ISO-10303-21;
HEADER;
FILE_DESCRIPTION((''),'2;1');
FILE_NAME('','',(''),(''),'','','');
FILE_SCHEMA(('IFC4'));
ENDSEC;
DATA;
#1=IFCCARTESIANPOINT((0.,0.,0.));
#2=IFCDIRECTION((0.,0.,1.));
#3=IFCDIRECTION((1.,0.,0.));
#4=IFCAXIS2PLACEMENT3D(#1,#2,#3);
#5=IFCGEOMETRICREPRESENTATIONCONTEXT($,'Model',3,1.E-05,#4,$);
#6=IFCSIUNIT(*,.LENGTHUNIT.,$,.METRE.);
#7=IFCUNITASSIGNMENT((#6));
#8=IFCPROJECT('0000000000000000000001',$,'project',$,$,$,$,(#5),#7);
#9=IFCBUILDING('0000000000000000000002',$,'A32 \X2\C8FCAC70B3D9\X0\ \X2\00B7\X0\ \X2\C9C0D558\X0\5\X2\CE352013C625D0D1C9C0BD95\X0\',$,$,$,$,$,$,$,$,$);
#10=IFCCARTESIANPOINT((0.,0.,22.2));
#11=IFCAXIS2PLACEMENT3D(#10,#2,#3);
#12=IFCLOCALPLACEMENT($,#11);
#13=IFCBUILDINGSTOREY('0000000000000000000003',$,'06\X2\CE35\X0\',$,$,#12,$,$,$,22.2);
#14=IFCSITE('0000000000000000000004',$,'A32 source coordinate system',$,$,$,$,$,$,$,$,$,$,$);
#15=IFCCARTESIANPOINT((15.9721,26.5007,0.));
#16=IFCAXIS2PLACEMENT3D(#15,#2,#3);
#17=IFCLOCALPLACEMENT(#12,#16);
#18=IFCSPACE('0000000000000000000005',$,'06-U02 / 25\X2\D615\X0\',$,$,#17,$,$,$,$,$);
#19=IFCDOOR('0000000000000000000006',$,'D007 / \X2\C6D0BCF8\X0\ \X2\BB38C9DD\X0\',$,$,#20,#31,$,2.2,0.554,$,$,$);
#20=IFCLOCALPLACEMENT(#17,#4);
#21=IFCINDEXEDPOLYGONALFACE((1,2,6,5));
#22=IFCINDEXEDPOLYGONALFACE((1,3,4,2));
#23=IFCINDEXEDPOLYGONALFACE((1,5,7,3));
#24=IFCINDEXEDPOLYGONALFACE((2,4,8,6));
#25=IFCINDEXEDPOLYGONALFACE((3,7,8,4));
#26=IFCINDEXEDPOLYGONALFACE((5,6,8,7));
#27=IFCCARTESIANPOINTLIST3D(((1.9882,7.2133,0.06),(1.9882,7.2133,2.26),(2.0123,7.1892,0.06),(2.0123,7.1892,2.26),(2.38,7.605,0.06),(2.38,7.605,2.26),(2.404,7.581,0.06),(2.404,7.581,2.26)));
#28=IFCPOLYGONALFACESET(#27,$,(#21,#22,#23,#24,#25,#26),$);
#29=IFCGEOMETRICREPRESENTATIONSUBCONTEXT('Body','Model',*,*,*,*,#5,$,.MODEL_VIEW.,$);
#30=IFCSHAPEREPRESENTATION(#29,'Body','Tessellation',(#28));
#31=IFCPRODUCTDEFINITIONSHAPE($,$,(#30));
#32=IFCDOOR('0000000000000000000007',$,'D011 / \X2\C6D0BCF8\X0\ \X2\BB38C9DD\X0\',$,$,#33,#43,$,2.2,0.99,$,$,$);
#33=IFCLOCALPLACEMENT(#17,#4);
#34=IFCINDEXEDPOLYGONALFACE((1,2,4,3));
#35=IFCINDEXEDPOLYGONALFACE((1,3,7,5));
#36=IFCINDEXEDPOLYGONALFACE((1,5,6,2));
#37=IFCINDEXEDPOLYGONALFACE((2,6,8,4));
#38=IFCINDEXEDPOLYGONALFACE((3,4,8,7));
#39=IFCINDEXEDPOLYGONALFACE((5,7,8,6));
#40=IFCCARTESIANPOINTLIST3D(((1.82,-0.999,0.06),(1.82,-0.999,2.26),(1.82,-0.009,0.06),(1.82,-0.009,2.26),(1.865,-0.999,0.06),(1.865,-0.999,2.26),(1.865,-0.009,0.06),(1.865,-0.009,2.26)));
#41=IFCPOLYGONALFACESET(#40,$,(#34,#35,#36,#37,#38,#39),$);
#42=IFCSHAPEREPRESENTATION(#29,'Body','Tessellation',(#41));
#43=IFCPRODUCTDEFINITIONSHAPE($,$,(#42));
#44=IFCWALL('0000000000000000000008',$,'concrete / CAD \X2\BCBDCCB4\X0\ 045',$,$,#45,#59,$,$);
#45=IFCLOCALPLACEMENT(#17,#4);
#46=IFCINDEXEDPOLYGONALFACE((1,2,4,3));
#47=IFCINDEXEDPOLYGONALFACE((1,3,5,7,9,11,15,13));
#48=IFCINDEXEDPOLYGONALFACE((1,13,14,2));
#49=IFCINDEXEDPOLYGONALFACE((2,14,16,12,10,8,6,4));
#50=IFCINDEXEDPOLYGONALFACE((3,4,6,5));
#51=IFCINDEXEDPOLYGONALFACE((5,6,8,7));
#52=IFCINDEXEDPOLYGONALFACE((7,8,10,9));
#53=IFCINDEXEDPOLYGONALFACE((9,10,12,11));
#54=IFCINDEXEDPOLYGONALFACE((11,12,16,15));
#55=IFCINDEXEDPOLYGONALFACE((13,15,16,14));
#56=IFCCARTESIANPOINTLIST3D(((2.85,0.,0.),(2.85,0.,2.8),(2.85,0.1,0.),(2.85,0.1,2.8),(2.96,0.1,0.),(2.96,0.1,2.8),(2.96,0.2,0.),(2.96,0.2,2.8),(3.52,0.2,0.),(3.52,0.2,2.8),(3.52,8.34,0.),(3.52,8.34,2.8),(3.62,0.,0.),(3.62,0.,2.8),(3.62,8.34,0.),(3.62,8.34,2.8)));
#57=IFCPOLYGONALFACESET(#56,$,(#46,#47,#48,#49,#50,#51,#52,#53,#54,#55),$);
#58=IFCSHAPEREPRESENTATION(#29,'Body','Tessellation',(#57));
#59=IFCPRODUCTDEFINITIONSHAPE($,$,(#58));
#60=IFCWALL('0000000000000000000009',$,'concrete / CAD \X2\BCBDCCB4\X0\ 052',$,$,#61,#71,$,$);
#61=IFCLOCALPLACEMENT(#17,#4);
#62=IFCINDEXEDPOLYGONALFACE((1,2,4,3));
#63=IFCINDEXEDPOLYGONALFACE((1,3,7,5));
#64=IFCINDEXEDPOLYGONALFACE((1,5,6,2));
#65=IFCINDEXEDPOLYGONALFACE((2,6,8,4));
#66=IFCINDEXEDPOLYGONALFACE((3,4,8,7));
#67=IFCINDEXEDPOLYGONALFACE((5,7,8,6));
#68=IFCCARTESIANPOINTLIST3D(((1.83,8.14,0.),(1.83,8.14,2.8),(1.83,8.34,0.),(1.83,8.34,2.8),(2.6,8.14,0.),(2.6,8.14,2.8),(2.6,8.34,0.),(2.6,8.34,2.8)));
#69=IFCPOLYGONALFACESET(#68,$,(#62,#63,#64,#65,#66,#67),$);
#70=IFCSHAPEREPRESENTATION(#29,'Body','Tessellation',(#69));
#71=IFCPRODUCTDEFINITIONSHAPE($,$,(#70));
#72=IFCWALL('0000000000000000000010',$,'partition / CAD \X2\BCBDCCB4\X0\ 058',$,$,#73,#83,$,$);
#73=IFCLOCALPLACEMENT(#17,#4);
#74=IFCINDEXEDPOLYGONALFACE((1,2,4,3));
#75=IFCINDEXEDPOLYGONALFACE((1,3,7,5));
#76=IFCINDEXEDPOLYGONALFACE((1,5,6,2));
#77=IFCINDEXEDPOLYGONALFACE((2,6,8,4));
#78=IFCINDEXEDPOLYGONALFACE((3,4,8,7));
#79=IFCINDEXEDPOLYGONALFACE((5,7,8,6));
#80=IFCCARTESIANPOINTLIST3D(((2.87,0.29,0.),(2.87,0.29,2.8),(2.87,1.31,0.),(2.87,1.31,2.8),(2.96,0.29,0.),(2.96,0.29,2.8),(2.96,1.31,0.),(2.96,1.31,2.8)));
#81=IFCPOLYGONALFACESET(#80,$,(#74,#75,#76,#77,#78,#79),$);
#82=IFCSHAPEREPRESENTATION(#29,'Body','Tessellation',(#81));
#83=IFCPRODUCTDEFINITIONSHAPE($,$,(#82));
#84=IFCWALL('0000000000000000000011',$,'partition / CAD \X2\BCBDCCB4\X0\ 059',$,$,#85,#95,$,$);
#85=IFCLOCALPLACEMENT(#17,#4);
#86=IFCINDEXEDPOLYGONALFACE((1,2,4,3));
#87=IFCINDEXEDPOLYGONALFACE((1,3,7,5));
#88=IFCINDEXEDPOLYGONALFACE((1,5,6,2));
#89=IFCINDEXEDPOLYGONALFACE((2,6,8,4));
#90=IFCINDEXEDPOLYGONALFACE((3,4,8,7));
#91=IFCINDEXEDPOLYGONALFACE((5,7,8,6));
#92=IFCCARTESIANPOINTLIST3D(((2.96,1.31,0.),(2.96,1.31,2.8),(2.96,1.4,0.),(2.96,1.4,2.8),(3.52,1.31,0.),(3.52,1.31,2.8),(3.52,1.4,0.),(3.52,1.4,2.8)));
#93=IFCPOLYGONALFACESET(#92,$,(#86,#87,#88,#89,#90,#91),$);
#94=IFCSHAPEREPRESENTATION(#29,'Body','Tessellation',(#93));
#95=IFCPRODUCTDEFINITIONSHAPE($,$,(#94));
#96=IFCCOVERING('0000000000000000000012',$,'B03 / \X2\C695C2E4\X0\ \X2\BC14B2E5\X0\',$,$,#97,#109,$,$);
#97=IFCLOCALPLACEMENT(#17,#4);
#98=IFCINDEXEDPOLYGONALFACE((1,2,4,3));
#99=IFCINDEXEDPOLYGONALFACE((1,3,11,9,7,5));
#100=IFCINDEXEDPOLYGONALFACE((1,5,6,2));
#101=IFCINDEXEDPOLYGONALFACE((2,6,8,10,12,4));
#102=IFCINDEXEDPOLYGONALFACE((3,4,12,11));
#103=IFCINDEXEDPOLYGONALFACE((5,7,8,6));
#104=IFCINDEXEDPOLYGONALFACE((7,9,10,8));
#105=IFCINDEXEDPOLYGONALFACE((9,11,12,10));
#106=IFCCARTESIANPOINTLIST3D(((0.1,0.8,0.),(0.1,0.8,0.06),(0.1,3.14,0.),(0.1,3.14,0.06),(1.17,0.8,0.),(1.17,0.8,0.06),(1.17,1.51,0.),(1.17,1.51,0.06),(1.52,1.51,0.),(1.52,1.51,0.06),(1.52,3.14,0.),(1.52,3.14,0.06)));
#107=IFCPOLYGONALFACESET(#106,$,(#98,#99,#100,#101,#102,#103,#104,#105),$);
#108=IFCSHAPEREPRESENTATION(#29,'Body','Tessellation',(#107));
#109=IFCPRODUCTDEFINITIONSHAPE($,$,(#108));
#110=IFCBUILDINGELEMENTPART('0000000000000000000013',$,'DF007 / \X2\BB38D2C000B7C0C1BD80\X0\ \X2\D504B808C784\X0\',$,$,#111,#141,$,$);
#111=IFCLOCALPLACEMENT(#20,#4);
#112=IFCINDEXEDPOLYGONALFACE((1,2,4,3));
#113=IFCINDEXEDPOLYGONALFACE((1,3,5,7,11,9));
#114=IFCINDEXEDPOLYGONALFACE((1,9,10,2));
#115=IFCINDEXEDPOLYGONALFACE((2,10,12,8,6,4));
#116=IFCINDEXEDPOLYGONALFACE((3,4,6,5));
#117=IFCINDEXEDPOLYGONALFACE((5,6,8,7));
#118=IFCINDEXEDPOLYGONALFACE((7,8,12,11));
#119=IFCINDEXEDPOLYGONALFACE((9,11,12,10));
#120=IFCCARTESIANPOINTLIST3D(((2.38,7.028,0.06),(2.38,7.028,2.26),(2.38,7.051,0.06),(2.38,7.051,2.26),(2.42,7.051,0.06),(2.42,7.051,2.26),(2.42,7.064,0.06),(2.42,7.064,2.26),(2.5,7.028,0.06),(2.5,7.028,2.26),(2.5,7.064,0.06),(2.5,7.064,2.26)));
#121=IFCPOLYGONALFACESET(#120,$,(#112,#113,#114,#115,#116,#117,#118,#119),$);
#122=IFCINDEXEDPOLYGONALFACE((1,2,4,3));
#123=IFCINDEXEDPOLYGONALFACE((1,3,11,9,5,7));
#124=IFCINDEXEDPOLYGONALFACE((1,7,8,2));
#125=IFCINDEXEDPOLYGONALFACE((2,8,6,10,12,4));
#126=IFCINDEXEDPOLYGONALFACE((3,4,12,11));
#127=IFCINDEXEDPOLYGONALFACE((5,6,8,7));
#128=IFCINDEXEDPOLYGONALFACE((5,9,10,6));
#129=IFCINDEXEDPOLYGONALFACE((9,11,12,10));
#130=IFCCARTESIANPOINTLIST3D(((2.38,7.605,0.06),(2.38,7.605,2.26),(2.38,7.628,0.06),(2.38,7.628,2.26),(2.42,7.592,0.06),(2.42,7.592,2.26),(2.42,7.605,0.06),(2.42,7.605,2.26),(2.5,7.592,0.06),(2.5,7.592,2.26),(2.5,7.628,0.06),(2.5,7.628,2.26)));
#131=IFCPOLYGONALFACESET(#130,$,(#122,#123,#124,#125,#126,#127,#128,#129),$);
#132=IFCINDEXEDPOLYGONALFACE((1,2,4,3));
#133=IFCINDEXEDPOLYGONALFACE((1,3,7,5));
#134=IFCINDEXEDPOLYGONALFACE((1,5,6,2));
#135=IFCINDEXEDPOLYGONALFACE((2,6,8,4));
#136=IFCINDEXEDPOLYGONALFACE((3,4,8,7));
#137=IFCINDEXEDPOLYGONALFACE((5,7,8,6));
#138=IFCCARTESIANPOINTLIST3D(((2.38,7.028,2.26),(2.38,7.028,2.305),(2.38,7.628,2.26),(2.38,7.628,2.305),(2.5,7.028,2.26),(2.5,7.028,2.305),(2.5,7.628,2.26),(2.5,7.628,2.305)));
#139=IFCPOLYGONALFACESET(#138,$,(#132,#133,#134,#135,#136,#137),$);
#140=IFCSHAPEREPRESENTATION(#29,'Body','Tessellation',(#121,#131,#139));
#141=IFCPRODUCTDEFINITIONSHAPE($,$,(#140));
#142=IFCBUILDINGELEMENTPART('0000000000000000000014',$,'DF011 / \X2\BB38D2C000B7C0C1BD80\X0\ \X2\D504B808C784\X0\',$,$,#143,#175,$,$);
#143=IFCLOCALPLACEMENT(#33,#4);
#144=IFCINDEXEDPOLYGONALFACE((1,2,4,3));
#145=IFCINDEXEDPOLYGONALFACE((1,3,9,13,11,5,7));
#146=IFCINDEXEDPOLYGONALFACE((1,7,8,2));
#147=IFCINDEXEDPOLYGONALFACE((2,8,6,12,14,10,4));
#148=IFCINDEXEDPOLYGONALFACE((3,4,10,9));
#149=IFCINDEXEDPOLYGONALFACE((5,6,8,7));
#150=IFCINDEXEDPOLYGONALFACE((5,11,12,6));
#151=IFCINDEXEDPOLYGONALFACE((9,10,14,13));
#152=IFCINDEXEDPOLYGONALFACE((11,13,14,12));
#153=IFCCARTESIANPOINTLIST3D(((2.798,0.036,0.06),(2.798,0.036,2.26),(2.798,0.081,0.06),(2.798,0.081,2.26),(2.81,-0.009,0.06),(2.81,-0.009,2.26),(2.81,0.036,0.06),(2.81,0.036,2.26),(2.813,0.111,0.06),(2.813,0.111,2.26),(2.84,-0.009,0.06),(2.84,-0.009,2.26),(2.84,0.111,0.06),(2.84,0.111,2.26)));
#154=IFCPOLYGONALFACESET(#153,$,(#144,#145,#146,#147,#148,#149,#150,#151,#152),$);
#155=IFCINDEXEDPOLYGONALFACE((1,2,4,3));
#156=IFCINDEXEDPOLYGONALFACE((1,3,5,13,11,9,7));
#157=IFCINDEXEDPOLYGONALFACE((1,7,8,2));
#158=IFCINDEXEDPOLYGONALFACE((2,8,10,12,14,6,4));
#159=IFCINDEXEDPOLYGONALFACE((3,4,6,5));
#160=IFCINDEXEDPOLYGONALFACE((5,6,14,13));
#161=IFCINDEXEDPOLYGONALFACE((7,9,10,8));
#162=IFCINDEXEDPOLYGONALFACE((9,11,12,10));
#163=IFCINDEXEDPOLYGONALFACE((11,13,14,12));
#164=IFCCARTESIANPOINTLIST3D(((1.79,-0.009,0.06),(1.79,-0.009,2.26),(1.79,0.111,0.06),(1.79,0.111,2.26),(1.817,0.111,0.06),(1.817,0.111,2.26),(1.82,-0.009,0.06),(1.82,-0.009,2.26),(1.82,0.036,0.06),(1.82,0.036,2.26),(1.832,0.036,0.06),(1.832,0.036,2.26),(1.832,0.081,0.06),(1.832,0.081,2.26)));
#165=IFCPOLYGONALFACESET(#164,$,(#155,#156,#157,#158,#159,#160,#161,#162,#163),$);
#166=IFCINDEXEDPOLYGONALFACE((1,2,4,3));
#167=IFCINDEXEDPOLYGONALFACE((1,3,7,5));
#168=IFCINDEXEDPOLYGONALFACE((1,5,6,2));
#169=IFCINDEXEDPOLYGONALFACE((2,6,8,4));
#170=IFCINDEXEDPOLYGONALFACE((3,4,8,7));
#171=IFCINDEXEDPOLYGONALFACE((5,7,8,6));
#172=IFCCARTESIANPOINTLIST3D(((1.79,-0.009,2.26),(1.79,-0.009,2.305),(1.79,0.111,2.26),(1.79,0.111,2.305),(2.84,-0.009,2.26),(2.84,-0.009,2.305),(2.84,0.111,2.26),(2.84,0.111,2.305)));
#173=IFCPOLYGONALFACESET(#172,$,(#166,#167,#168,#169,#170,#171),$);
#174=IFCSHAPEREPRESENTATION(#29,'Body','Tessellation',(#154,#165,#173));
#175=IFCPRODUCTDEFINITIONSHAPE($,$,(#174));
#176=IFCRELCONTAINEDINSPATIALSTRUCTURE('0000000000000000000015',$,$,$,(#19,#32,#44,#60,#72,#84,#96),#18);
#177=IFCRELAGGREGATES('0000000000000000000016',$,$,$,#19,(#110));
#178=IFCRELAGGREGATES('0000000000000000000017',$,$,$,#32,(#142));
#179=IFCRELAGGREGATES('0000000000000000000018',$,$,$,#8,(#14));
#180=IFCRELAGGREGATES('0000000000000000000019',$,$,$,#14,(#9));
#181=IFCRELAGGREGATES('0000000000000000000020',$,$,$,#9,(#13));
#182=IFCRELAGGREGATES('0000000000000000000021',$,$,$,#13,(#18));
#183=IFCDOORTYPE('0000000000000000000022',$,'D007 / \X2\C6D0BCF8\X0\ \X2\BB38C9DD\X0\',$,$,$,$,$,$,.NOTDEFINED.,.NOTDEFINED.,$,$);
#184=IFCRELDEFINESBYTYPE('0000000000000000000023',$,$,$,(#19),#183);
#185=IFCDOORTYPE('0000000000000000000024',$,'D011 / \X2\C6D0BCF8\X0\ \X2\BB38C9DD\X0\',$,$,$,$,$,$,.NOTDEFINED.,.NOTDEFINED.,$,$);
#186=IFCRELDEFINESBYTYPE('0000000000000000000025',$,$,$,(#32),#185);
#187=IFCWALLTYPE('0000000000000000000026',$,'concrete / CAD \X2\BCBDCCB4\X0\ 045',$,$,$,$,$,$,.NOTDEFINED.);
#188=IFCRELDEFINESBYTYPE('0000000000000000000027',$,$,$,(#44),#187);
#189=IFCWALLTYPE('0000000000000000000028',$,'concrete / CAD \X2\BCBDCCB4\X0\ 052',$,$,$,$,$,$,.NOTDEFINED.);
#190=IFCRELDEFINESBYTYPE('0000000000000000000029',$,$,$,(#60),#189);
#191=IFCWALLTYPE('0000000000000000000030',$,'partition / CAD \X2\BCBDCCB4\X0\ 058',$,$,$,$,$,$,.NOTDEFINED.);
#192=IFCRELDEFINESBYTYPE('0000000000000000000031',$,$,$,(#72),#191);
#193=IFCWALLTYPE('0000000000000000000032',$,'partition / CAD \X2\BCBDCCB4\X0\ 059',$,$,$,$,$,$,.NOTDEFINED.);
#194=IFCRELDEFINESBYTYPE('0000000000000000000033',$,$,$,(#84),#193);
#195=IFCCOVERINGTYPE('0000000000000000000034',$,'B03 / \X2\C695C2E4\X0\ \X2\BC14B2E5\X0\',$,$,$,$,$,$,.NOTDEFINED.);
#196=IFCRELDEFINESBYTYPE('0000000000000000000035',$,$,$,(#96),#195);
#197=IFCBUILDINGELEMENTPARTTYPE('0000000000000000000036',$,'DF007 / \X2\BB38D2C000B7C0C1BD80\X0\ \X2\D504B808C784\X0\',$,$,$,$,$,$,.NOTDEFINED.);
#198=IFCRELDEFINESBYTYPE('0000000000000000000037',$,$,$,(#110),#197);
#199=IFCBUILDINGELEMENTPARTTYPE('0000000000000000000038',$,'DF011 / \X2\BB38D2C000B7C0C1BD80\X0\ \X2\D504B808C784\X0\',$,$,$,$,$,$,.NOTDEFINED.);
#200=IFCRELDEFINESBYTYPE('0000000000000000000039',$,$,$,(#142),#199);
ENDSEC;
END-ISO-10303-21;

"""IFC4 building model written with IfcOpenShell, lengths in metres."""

from ifc_helpers import new_model, si_unit, frame, origin, origin_with_axes, place, context, subcontext, project, spatial, polyline, outline, extrude, source, transform, mapped, type_object, type_shapes, element, aggregate, save


model = new_model("IFC4")

# Units and contexts
model_context = context("Model", 3, precision=1e-05, world=origin_with_axes())
body_context = subcontext(model_context, "Body", "Model", "MODEL_VIEW")
ifc_project = project(units=[si_unit("LENGTHUNIT", "METRE")], contexts=[model_context])

# Site, building, storey, space
storey_placement = place(None, frame((0.0, 0.0, 22.2), z_axis=(0.0, 0.0, 1.0), x_axis=(1.0, 0.0, 0.0)))
space_placement = place(storey_placement, frame((15.9721, 26.5007, 0.0), z_axis=(0.0, 0.0, 1.0), x_axis=(1.0, 0.0, 0.0)))
site = spatial("IfcSite", under=ifc_project, Name="A32 source coordinate system")
building = spatial("IfcBuilding", under=site, Name="A32 주거동 · 지하5층–옥탑지붕")
storey = spatial("IfcBuildingStorey", under=building, at=storey_placement, Name="06층", Elevation=22.2)
space = spatial("IfcSpace", under=storey, at=space_placement, Name="06-U02 / 25형")

# Doors
door_type_1 = type_object("IfcDoorType", Name="D007 / 원본 문짝", OperationType="NOTDEFINED", PredefinedType="NOTDEFINED")
shared_shape_1 = source(origin(), body_context, "Body", "SweptSolid", [
    extrude(outline(polyline([(2.0123, 7.1892), (1.9882, 7.2133), (2.38, 7.605), (2.404, 7.581), (2.0123, 7.1892)])), frame((0.0, 0.0, 0.06)), (0.0, 0.0, 1.0), 2.2),
])
type_shapes(door_type_1, [shared_shape_1])
door_1_placement = place(space_placement, origin_with_axes())
door_1 = element("IfcDoor", 1, at=door_1_placement, inside=space, type_object=door_type_1, Name="D007 / 원본 문짝", OverallHeight=2.2, OverallWidth=0.554, context=body_context, shape_type="MappedRepresentation", body=[
    mapped(shared_shape_1, transform((0.0, 0.0, 0.0), scale=1.0)),
])
door_type_2 = type_object("IfcDoorType", Name="D011 / 원본 문짝", OperationType="NOTDEFINED", PredefinedType="NOTDEFINED")
shared_shape_2 = source(origin(), body_context, "Body", "SweptSolid", [
    extrude(outline(polyline([(1.865, -0.999), (1.82, -0.999), (1.82, -0.009), (1.865, -0.009), (1.865, -0.999)])), frame((0.0, 0.0, 0.06)), (0.0, 0.0, 1.0), 2.2),
])
type_shapes(door_type_2, [shared_shape_2])
door_2_placement = place(space_placement, origin_with_axes())
door_2 = element("IfcDoor", 2, at=door_2_placement, inside=space, type_object=door_type_2, Name="D011 / 원본 문짝", OverallHeight=2.2, OverallWidth=0.99, context=body_context, shape_type="MappedRepresentation", body=[
    mapped(shared_shape_2, transform((0.0, 0.0, 0.0), scale=1.0)),
])

# Walls
wall_type_1 = type_object("IfcWallType", Name="concrete / CAD 벽체 045", PredefinedType="NOTDEFINED")
shared_shape_3 = source(origin(), body_context, "Body", "SweptSolid", [
    extrude(outline(polyline([(2.96, 0.1), (2.96, 0.2), (3.52, 0.2), (3.52, 8.34), (3.72, 8.34), (3.72, 8.34), (3.62, 8.34), (3.62, 0.0), (2.85, 0.0), (2.85, 0.1), (2.96, 0.1)])), origin(), (0.0, 0.0, 1.0), 2.8),
])
type_shapes(wall_type_1, [shared_shape_3])
wall_1_placement = place(space_placement, origin_with_axes())
element("IfcWall", 3, at=wall_1_placement, inside=space, type_object=wall_type_1, Name="concrete / CAD 벽체 045", context=body_context, shape_type="MappedRepresentation", body=[
    mapped(shared_shape_3, transform((0.0, 0.0, 0.0), scale=1.0)),
])
wall_type_2 = type_object("IfcWallType", Name="concrete / CAD 벽체 052", PredefinedType="NOTDEFINED")
shared_shape_4 = source(origin(), body_context, "Body", "SweptSolid", [
    extrude(outline(polyline([(2.6, 8.14), (1.83, 8.14), (1.83, 8.34), (2.6, 8.34), (2.6, 8.14)])), origin(), (0.0, 0.0, 1.0), 2.8),
])
type_shapes(wall_type_2, [shared_shape_4])
wall_2_placement = place(space_placement, origin_with_axes())
element("IfcWall", 4, at=wall_2_placement, inside=space, type_object=wall_type_2, Name="concrete / CAD 벽체 052", context=body_context, shape_type="MappedRepresentation", body=[
    mapped(shared_shape_4, transform((0.0, 0.0, 0.0), scale=1.0)),
])
wall_type_3 = type_object("IfcWallType", Name="partition / CAD 벽체 058", PredefinedType="NOTDEFINED")
shared_shape_5 = source(origin(), body_context, "Body", "SweptSolid", [
    extrude(outline(polyline([(2.96, 1.31), (2.96, 0.29), (2.87, 0.29), (2.87, 1.31), (2.96, 1.31)])), origin(), (0.0, 0.0, 1.0), 2.8),
])
type_shapes(wall_type_3, [shared_shape_5])
wall_3_placement = place(space_placement, origin_with_axes())
element("IfcWall", 5, at=wall_3_placement, inside=space, type_object=wall_type_3, Name="partition / CAD 벽체 058", context=body_context, shape_type="MappedRepresentation", body=[
    mapped(shared_shape_5, transform((0.0, 0.0, 0.0), scale=1.0)),
])
wall_type_4 = type_object("IfcWallType", Name="partition / CAD 벽체 059", PredefinedType="NOTDEFINED")
shared_shape_6 = source(origin(), body_context, "Body", "SweptSolid", [
    extrude(outline(polyline([(3.52, 1.31), (2.96, 1.31), (2.96, 1.4), (3.52, 1.4), (3.52, 1.31)])), origin(), (0.0, 0.0, 1.0), 2.8),
])
type_shapes(wall_type_4, [shared_shape_6])
wall_4_placement = place(space_placement, origin_with_axes())
element("IfcWall", 6, at=wall_4_placement, inside=space, type_object=wall_type_4, Name="partition / CAD 벽체 059", context=body_context, shape_type="MappedRepresentation", body=[
    mapped(shared_shape_6, transform((0.0, 0.0, 0.0), scale=1.0)),
])

# Covering
covering_type_1 = type_object("IfcCoveringType", Name="B03 / 욕실 바닥", PredefinedType="NOTDEFINED")
shared_shape_7 = source(origin(), body_context, "Body", "SweptSolid", [
    extrude(outline(polyline([(1.17, 1.51), (1.17, 0.8), (0.1, 0.8), (0.1, 3.14), (1.52, 3.14), (1.52, 1.51), (1.17, 1.51)])), origin(), (0.0, 0.0, 1.0), 0.06),
])
type_shapes(covering_type_1, [shared_shape_7])
covering_1_placement = place(space_placement, origin_with_axes())
element("IfcCovering", 7, at=covering_1_placement, inside=space, type_object=covering_type_1, Name="B03 / 욕실 바닥", context=body_context, shape_type="MappedRepresentation", body=[
    mapped(shared_shape_7, transform((0.0, 0.0, 0.0), scale=1.0)),
])

# Building element parts
building_element_part_type_1 = type_object("IfcBuildingElementPartType", Name="DF007 / 문틀·상부 프레임", PredefinedType="NOTDEFINED")
shared_shape_8 = source(origin(), body_context, "Body", "SweptSolid", [
    extrude(outline(polyline([(2.38, 7.028), (2.38, 7.051), (2.42, 7.051), (2.42, 7.064), (2.5, 7.064), (2.5, 7.028), (2.38, 7.028)])), frame((0.0, 0.0, 0.06)), (0.0, 0.0, 1.0), 2.2),
    extrude(outline(polyline([(2.5, 7.592), (2.42, 7.592), (2.42, 7.605), (2.38, 7.605), (2.38, 7.628), (2.5, 7.628), (2.5, 7.592)])), frame((0.0, 0.0, 0.06)), (0.0, 0.0, 1.0), 2.2),
    extrude(outline(polyline([(2.38, 7.028), (2.38, 7.628), (2.5, 7.628), (2.5, 7.028), (2.38, 7.028)])), frame((0.0, 0.0, 2.26)), (0.0, 0.0, 1.0), 0.045),
])
type_shapes(building_element_part_type_1, [shared_shape_8])
building_element_part_1_placement = place(door_1_placement, origin_with_axes())
building_element_part_1 = element("IfcBuildingElementPart", 8, at=building_element_part_1_placement, type_object=building_element_part_type_1, Name="DF007 / 문틀·상부 프레임", context=body_context, shape_type="MappedRepresentation", body=[
    mapped(shared_shape_8, transform((0.0, 0.0, 0.0), scale=1.0)),
])
aggregate(door_1, [building_element_part_1])
building_element_part_type_2 = type_object("IfcBuildingElementPartType", Name="DF011 / 문틀·상부 프레임", PredefinedType="NOTDEFINED")
shared_shape_9 = source(origin(), body_context, "Body", "SweptSolid", [
    extrude(outline(polyline([(2.81, -0.009), (2.81, 0.036), (2.798, 0.036), (2.798, 0.081), (2.813, 0.111), (2.84, 0.111), (2.84, -0.009), (2.81, -0.009)])), frame((0.0, 0.0, 0.06)), (0.0, 0.0, 1.0), 2.2),
    extrude(outline(polyline([(1.79, 0.111), (1.817, 0.111), (1.832, 0.081), (1.832, 0.036), (1.82, 0.036), (1.82, -0.009), (1.79, -0.009), (1.79, 0.111)])), frame((0.0, 0.0, 0.06)), (0.0, 0.0, 1.0), 2.2),
    extrude(outline(polyline([(1.79, -0.009), (1.79, 0.111), (2.84, 0.111), (2.84, -0.009), (1.79, -0.009)])), frame((0.0, 0.0, 2.26)), (0.0, 0.0, 1.0), 0.045),
])
type_shapes(building_element_part_type_2, [shared_shape_9])
building_element_part_2_placement = place(door_2_placement, origin_with_axes())
building_element_part_2 = element("IfcBuildingElementPart", 9, at=building_element_part_2_placement, type_object=building_element_part_type_2, Name="DF011 / 문틀·상부 프레임", context=body_context, shape_type="MappedRepresentation", body=[
    mapped(shared_shape_9, transform((0.0, 0.0, 0.0), scale=1.0)),
])
aggregate(door_2, [building_element_part_2])

save(model, "model.ifc")
